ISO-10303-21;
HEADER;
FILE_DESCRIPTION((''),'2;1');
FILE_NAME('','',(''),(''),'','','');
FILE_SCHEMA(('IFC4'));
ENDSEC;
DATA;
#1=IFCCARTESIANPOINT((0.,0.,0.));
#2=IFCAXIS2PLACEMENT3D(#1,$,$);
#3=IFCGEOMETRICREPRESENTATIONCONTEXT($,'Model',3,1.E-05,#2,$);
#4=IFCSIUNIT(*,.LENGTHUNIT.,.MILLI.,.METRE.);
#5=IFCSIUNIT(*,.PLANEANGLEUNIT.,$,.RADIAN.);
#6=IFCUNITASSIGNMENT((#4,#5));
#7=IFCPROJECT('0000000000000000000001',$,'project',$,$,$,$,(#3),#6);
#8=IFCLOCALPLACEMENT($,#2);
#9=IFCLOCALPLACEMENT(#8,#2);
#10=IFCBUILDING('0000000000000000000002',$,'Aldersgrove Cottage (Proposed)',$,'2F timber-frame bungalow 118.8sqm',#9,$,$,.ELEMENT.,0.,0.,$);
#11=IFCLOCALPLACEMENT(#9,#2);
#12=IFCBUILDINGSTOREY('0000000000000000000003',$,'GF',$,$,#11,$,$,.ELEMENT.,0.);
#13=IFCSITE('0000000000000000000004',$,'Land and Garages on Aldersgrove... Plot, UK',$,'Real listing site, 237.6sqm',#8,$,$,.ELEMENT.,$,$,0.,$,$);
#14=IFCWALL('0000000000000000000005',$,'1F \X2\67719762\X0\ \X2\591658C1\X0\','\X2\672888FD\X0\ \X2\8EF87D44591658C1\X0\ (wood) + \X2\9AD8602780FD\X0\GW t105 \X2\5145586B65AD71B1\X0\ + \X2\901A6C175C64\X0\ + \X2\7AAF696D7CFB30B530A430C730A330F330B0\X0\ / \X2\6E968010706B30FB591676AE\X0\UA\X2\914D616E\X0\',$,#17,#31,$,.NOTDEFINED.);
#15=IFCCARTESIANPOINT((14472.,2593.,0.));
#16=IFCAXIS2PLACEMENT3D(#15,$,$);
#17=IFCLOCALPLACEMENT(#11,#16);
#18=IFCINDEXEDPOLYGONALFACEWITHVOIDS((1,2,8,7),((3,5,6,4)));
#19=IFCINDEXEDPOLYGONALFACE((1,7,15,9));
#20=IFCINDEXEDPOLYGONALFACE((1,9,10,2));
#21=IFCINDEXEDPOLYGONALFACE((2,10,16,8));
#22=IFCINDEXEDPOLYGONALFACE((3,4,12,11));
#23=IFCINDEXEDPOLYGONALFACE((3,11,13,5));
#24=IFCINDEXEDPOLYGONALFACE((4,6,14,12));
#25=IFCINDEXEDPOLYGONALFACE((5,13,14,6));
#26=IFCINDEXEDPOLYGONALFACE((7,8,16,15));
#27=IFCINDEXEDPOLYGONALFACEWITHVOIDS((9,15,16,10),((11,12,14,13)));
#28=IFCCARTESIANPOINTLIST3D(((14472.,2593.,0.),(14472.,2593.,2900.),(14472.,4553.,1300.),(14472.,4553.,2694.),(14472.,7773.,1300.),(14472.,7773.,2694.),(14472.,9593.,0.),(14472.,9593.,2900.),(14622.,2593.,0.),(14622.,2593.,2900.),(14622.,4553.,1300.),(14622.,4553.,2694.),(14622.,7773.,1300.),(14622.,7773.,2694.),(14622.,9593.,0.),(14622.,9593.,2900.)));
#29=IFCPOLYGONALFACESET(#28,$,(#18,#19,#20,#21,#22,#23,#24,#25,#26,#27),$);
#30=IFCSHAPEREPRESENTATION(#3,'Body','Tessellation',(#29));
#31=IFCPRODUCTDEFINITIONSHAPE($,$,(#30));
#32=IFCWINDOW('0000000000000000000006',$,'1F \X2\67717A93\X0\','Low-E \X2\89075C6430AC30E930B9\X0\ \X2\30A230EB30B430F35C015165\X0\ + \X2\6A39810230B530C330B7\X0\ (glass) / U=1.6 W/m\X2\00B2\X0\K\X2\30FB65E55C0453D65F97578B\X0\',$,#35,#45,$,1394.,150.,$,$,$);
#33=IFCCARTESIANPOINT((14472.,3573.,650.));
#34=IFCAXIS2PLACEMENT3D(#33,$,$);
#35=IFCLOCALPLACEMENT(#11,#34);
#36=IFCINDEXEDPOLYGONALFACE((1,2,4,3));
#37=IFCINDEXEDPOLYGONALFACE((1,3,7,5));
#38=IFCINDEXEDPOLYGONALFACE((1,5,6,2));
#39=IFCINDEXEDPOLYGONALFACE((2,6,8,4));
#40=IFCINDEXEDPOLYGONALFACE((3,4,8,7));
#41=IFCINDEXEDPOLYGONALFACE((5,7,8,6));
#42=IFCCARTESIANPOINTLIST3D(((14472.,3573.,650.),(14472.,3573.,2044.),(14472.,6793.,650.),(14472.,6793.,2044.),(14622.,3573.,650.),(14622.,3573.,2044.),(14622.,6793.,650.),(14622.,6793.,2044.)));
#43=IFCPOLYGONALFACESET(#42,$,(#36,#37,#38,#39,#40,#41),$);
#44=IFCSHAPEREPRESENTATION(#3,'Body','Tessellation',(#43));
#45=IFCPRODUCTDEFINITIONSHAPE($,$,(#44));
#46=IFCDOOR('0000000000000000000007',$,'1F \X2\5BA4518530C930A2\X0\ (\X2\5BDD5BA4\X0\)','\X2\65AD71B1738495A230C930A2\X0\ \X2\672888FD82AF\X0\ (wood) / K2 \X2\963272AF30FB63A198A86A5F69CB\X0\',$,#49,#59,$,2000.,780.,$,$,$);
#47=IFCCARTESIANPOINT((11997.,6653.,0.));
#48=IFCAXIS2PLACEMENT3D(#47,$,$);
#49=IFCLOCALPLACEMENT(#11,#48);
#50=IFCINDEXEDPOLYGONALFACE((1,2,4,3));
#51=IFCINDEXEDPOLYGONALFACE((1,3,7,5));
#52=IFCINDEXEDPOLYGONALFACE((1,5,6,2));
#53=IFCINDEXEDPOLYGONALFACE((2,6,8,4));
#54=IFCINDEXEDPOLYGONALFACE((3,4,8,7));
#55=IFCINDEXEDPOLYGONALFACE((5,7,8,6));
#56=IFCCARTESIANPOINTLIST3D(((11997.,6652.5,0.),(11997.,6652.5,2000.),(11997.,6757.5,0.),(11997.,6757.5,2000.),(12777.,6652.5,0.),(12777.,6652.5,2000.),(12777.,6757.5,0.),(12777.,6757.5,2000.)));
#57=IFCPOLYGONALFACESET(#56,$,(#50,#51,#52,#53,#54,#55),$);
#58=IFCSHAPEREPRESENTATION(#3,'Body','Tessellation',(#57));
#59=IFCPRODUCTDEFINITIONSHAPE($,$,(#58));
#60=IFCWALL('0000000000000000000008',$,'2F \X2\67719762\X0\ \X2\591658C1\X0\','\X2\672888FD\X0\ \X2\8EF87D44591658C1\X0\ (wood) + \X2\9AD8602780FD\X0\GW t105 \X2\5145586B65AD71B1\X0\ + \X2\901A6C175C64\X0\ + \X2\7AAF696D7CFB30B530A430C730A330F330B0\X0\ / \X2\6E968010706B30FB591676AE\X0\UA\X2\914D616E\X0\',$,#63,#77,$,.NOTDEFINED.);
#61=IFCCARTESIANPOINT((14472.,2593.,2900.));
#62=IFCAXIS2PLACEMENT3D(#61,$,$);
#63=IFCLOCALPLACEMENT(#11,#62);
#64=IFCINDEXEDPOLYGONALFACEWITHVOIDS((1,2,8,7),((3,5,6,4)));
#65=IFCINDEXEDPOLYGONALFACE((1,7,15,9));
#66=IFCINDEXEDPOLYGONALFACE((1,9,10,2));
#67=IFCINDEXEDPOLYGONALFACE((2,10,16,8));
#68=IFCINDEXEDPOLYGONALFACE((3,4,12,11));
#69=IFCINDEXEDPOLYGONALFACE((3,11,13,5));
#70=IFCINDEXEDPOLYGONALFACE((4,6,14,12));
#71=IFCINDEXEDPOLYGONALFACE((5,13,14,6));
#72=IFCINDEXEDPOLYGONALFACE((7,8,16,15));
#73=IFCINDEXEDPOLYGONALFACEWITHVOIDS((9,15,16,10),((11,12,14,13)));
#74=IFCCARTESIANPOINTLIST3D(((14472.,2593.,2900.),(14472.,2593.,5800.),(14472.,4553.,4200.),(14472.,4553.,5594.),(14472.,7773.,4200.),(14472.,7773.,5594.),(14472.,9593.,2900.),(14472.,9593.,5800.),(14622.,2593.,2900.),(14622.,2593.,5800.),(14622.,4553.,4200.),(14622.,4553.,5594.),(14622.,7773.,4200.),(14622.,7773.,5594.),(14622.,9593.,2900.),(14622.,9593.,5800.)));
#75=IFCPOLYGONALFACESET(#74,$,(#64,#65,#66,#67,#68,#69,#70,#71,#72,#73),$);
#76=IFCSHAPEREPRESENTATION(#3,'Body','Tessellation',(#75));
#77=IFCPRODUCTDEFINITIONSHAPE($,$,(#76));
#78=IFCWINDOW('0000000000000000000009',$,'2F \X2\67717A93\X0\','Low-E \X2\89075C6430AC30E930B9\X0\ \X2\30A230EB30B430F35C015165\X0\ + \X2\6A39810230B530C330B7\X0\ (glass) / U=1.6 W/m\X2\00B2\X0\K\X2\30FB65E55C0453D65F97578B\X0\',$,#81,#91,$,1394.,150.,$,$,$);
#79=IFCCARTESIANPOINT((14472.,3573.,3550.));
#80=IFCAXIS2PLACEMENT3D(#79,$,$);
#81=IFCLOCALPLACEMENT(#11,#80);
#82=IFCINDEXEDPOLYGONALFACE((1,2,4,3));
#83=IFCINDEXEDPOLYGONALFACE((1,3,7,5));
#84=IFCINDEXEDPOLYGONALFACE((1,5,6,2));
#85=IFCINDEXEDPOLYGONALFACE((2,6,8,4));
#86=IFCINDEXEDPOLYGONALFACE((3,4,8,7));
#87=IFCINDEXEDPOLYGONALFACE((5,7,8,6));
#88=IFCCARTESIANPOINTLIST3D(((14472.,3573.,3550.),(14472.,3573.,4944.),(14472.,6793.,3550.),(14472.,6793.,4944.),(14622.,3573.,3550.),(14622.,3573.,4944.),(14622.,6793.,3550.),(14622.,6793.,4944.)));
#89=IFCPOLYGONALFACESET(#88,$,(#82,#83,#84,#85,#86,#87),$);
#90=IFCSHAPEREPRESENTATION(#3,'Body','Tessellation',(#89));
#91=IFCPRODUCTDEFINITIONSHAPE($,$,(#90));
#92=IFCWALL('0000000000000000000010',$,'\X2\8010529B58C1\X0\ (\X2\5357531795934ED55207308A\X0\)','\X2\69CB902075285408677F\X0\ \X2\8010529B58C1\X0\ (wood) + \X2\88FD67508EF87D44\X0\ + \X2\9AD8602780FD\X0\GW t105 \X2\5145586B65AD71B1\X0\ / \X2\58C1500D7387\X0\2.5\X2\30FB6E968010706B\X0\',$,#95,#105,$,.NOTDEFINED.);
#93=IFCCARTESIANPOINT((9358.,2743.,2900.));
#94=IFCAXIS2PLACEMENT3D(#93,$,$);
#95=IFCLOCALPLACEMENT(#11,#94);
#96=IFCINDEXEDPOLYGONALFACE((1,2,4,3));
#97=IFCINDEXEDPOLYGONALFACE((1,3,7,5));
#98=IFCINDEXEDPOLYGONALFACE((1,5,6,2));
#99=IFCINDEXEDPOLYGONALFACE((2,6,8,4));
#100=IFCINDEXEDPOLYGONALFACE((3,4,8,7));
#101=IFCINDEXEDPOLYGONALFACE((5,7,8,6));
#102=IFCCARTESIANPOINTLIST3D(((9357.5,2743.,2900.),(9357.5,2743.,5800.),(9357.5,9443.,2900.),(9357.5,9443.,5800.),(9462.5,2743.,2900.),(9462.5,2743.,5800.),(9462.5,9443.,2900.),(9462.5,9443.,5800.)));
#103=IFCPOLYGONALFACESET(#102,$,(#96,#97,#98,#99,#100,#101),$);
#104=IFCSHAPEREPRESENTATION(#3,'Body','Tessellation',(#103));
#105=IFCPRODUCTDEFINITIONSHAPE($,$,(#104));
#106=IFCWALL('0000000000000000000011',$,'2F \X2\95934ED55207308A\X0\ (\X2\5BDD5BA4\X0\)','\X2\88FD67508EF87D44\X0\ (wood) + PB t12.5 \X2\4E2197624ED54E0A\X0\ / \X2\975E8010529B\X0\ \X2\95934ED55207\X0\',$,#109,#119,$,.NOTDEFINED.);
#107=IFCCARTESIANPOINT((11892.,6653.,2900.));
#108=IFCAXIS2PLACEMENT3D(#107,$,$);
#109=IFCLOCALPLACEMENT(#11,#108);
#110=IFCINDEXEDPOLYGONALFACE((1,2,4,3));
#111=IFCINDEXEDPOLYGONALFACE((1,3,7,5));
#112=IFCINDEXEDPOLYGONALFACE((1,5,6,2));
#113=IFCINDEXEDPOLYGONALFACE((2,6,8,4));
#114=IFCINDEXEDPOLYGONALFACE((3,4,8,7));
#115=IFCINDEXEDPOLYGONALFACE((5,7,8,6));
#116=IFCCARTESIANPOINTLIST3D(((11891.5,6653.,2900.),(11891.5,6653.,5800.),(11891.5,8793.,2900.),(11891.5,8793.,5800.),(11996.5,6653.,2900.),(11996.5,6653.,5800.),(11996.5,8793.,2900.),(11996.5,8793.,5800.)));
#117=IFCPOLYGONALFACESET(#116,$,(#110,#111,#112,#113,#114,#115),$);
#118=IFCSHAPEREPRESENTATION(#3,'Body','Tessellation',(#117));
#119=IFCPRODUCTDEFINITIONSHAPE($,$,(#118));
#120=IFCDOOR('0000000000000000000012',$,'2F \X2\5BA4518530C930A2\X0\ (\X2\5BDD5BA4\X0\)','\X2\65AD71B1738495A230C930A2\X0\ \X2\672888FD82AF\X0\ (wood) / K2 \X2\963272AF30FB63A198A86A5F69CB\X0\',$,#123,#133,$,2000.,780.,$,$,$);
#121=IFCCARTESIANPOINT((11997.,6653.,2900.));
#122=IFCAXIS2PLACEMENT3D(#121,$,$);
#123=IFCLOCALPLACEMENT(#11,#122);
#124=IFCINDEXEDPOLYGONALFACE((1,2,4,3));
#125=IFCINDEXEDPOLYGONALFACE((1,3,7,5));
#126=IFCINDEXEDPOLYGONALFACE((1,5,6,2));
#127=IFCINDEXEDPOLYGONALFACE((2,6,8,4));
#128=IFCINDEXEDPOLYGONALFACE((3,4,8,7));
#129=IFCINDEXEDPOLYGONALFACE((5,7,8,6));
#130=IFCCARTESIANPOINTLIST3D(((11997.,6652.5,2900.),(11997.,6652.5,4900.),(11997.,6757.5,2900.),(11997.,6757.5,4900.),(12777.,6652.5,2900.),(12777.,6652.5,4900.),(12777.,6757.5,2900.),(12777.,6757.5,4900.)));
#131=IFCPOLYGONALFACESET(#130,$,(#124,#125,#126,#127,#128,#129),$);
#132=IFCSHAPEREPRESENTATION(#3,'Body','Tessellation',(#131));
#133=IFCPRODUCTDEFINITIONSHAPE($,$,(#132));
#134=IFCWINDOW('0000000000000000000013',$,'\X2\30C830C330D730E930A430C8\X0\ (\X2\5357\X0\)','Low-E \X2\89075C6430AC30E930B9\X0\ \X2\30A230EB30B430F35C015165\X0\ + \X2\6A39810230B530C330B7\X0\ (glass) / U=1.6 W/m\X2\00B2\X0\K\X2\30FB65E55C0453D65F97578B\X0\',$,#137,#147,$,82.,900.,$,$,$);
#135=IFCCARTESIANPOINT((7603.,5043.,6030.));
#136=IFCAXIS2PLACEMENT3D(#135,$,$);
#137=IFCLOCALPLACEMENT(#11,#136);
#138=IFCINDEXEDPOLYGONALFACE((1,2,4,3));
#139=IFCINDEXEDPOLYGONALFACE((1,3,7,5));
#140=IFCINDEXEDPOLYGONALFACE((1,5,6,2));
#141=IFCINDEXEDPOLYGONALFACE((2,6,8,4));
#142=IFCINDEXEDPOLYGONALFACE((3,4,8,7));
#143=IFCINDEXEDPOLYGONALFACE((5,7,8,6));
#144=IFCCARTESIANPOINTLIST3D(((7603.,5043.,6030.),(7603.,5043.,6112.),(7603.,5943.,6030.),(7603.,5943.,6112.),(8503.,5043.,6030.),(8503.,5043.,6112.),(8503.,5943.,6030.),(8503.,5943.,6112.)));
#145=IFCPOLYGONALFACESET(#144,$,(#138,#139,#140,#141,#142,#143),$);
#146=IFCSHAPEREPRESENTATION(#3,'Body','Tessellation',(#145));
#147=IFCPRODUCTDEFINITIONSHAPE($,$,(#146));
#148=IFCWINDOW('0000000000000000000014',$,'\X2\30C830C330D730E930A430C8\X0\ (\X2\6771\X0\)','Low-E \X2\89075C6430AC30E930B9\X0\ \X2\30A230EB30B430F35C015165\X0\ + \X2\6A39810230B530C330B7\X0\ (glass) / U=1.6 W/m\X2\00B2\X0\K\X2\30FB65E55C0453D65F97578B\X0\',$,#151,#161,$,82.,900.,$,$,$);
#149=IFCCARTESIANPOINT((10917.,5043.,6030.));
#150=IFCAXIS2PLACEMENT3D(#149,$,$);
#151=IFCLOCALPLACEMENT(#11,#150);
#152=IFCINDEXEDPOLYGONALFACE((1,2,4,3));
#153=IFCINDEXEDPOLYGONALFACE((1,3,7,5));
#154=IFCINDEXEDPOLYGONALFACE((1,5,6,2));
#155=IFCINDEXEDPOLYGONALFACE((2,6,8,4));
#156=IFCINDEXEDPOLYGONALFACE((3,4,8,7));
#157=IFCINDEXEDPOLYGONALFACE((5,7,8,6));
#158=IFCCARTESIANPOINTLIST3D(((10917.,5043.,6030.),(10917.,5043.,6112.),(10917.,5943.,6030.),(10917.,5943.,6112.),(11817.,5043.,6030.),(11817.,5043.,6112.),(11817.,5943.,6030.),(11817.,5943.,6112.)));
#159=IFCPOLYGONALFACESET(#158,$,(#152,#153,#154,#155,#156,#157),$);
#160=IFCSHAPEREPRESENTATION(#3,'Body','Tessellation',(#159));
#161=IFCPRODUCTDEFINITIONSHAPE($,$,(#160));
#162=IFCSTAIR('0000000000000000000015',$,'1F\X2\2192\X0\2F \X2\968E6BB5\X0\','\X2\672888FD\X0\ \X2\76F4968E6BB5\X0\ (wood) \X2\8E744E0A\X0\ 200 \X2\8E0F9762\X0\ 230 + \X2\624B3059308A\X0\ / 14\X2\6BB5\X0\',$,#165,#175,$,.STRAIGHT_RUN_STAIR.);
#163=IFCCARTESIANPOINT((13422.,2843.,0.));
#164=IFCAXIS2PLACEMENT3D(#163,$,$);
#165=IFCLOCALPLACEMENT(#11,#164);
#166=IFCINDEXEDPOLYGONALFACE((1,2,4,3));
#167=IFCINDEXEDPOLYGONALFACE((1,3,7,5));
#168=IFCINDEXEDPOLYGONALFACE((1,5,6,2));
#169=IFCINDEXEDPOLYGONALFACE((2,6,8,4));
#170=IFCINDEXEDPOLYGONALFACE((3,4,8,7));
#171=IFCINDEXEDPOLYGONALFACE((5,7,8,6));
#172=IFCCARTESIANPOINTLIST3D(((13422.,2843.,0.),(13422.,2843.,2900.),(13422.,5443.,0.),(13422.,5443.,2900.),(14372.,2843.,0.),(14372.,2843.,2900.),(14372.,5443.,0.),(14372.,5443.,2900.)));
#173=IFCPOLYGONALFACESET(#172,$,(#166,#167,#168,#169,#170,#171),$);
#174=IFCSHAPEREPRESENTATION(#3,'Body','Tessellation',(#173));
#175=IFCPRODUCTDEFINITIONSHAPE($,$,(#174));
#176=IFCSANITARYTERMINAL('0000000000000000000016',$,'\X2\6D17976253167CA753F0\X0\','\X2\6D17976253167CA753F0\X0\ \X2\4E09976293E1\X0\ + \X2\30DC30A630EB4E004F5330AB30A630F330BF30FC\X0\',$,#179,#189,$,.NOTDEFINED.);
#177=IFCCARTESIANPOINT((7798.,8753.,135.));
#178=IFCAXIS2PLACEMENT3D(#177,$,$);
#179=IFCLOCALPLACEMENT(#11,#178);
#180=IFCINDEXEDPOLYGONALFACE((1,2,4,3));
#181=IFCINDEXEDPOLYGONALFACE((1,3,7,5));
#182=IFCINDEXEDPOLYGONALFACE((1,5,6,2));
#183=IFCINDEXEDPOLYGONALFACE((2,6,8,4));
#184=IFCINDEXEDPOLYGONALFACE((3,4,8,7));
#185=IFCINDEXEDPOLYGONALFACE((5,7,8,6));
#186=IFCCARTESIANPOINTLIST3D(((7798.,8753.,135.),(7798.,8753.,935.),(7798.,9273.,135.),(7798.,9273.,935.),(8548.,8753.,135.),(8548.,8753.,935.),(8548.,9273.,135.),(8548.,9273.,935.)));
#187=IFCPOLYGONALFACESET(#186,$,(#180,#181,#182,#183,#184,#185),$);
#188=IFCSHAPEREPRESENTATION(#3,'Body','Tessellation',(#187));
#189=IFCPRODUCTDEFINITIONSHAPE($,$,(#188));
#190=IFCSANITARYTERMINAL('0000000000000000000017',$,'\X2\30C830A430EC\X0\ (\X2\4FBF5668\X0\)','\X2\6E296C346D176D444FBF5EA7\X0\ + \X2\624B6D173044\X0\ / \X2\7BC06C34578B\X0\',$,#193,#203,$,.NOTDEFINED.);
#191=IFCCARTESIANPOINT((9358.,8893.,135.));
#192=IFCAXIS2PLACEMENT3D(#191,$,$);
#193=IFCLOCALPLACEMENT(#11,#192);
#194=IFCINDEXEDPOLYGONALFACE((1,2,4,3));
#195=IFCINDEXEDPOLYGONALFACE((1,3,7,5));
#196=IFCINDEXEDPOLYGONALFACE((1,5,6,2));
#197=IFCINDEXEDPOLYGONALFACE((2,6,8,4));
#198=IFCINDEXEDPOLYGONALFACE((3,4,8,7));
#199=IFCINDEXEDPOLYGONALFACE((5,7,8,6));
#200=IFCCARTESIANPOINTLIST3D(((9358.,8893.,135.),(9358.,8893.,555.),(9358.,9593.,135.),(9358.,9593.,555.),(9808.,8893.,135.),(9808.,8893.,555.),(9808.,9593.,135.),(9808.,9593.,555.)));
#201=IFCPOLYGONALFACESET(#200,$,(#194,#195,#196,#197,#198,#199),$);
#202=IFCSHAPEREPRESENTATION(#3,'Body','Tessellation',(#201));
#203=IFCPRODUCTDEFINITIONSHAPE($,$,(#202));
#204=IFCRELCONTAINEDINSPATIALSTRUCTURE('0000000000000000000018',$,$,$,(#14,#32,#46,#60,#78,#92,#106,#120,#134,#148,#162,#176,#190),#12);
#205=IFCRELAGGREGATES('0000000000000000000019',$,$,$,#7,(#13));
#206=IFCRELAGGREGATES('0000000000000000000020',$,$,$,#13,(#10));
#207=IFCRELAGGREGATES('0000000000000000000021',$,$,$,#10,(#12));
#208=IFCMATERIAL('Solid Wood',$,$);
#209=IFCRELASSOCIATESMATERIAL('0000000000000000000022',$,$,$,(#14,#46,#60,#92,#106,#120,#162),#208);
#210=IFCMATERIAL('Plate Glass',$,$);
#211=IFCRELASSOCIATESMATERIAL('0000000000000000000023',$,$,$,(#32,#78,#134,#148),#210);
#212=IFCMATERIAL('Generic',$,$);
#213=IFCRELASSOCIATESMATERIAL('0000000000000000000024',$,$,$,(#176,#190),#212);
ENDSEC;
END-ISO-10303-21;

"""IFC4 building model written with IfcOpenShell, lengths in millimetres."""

from ifc_helpers import new_model, si_unit, frame, frame_2d, origin, place, context, project, spatial, rectangle, extrude, material, element, fill, save


model = new_model("IFC4")

# Units and contexts
model_context = context("Model", 3, precision=1e-05, world=origin())
ifc_project = project(units=[si_unit("LENGTHUNIT", "METRE", prefix="MILLI"), si_unit("PLANEANGLEUNIT", "RADIAN")], contexts=[model_context])

# Site, building, storey
site_placement = place(None, origin())
site = spatial("IfcSite", under=ifc_project, at=site_placement, Name="Land and Garages on Aldersgrove... Plot, UK", ObjectType="Real listing site, 237.6sqm", CompositionType="ELEMENT", RefElevation=0.0)
building_placement = place(site_placement, origin())
building = spatial("IfcBuilding", under=site, at=building_placement, Name="Aldersgrove Cottage (Proposed)", ObjectType="2F timber-frame bungalow 118.8sqm", CompositionType="ELEMENT", ElevationOfRefHeight=0.0, ElevationOfTerrain=0.0)
storey_placement = place(building_placement, origin())
storey = spatial("IfcBuildingStorey", under=building, at=storey_placement, Name="GF", CompositionType="ELEMENT", Elevation=0.0)

# Wall, opening, window
ifc_material_1 = material(Name="Solid Wood")
wall_1_placement = place(storey_placement, frame((14472.0, 2593.0, 0.0)))
wall_1 = element("IfcWall", 1, at=wall_1_placement, inside=storey, material=ifc_material_1, Name="1F 東面 外壁", Description="木製 軸組外壁 (wood) + 高性能GW t105 充填断熱 + 通気層 + 窯業系サイディング / 準耐火・外皮UA配慮", PredefinedType="NOTDEFINED", context=model_context, shape_type="SweptSolid", body=[
    extrude(rectangle(XDim=150.0, YDim=7000.0, at=frame_2d((75.0, 3500.0))), frame((14472.0, 2593.0, 0.0)), (0.0, 0.0, 1.0), 2900.0),
])
opening_1_placement = place(storey_placement, frame((14472.0, 3573.0, 650.0)))
opening_1 = element("IfcOpeningElement", 2, at=opening_1_placement, cuts=wall_1, PredefinedType="NOTDEFINED", context=model_context, shape_type="SweptSolid", body=[
    extrude(rectangle(XDim=150.0, YDim=3220.0, at=frame_2d((75.0, 1610.0))), frame((14472.0, 3573.0, 650.0)), (0.0, 0.0, 1.0), 1394.0),
])
ifc_material_2 = material(Name="Plate Glass")
window_1_placement = place(storey_placement, frame((14472.0, 3573.0, 650.0)))
window_1 = element("IfcWindow", 3, at=window_1_placement, inside=storey, material=ifc_material_2, Name="1F 東窓", Description="Low-E 複層ガラス アルゴン封入 + 樹脂サッシ (glass) / U=1.6 W/m²K・日射取得型", OverallHeight=1394.0, OverallWidth=150.0, context=model_context, shape_type="SweptSolid", body=[
    extrude(rectangle(XDim=150.0, YDim=3220.0, at=frame_2d((75.0, 1610.0))), frame((14472.0, 3573.0, 650.0)), (0.0, 0.0, 1.0), 1394.0),
])
fill(opening_1, window_1)

# Door
door_1_placement = place(storey_placement, frame((11997.0, 6653.0, 0.0)))
element("IfcDoor", 4, at=door_1_placement, inside=storey, material=ifc_material_1, Name="1F 室内ドア (寝室)", Description="断熱玄関ドア 木製芯 (wood) / K2 防犯・採風機構", OverallHeight=2000.0, OverallWidth=780.0, context=model_context, shape_type="SweptSolid", body=[
    extrude(rectangle(XDim=780.0, YDim=105.0, at=frame_2d((390.0, 52.0))), frame((11997.0, 6653.0, 0.0)), (0.0, 0.0, 1.0), 2000.0),
])

# Wall, opening, window
wall_2_placement = place(storey_placement, frame((14472.0, 2593.0, 2900.0)))
wall_2 = element("IfcWall", 5, at=wall_2_placement, inside=storey, material=ifc_material_1, Name="2F 東面 外壁", Description="木製 軸組外壁 (wood) + 高性能GW t105 充填断熱 + 通気層 + 窯業系サイディング / 準耐火・外皮UA配慮", PredefinedType="NOTDEFINED", context=model_context, shape_type="SweptSolid", body=[
    extrude(rectangle(XDim=150.0, YDim=7000.0, at=frame_2d((75.0, 3500.0))), frame((14472.0, 2593.0, 2900.0)), (0.0, 0.0, 1.0), 2900.0),
])
opening_2_placement = place(storey_placement, frame((14472.0, 3573.0, 3550.0)))
opening_2 = element("IfcOpeningElement", 6, at=opening_2_placement, cuts=wall_2, PredefinedType="NOTDEFINED", context=model_context, shape_type="SweptSolid", body=[
    extrude(rectangle(XDim=150.0, YDim=3220.0, at=frame_2d((75.0, 1610.0))), frame((14472.0, 3573.0, 3550.0)), (0.0, 0.0, 1.0), 1394.0),
])
window_2_placement = place(storey_placement, frame((14472.0, 3573.0, 3550.0)))
window_2 = element("IfcWindow", 7, at=window_2_placement, inside=storey, material=ifc_material_2, Name="2F 東窓", Description="Low-E 複層ガラス アルゴン封入 + 樹脂サッシ (glass) / U=1.6 W/m²K・日射取得型", OverallHeight=1394.0, OverallWidth=150.0, context=model_context, shape_type="SweptSolid", body=[
    extrude(rectangle(XDim=150.0, YDim=3220.0, at=frame_2d((75.0, 1610.0))), frame((14472.0, 3573.0, 3550.0)), (0.0, 0.0, 1.0), 1394.0),
])
fill(opening_2, window_2)

# Walls
wall_3_placement = place(storey_placement, frame((9358.0, 2743.0, 2900.0)))
element("IfcWall", 8, at=wall_3_placement, inside=storey, material=ifc_material_1, Name="耐力壁 (南北間仕切り)", Description="構造用合板 耐力壁 (wood) + 製材軸組 + 高性能GW t105 充填断熱 / 壁倍率2.5・準耐火", PredefinedType="NOTDEFINED", context=model_context, shape_type="SweptSolid", body=[
    extrude(rectangle(XDim=105.0, YDim=6700.0, at=frame_2d((52.0, 3350.0))), frame((9358.0, 2743.0, 2900.0)), (0.0, 0.0, 1.0), 2900.0),
])
wall_4_placement = place(storey_placement, frame((11892.0, 6653.0, 2900.0)))
element("IfcWall", 9, at=wall_4_placement, inside=storey, material=ifc_material_1, Name="2F 間仕切り (寝室)", Description="製材軸組 (wood) + PB t12.5 両面仕上 / 非耐力 間仕切", PredefinedType="NOTDEFINED", context=model_context, shape_type="SweptSolid", body=[
    extrude(rectangle(XDim=105.0, YDim=2140.0, at=frame_2d((52.0, 1070.0))), frame((11892.0, 6653.0, 2900.0)), (0.0, 0.0, 1.0), 2900.0),
])

# Door
door_2_placement = place(storey_placement, frame((11997.0, 6653.0, 2900.0)))
element("IfcDoor", 10, at=door_2_placement, inside=storey, material=ifc_material_1, Name="2F 室内ドア (寝室)", Description="断熱玄関ドア 木製芯 (wood) / K2 防犯・採風機構", OverallHeight=2000.0, OverallWidth=780.0, context=model_context, shape_type="SweptSolid", body=[
    extrude(rectangle(XDim=780.0, YDim=105.0, at=frame_2d((390.0, 52.0))), frame((11997.0, 6653.0, 2900.0)), (0.0, 0.0, 1.0), 2000.0),
])

# Windows
window_3_placement = place(storey_placement, frame((7603.0, 5043.0, 6030.0)))
element("IfcWindow", 11, at=window_3_placement, inside=storey, material=ifc_material_2, Name="トップライト (南)", Description="Low-E 複層ガラス アルゴン封入 + 樹脂サッシ (glass) / U=1.6 W/m²K・日射取得型", OverallHeight=82.0, OverallWidth=900.0, context=model_context, shape_type="SweptSolid", body=[
    extrude(rectangle(XDim=900.0, YDim=900.0, at=frame_2d((450.0, 450.0))), frame((7603.0, 5043.0, 6030.0)), (0.0, 0.0, 1.0), 82.0),
])
window_4_placement = place(storey_placement, frame((10917.0, 5043.0, 6030.0)))
element("IfcWindow", 12, at=window_4_placement, inside=storey, material=ifc_material_2, Name="トップライト (東)", Description="Low-E 複層ガラス アルゴン封入 + 樹脂サッシ (glass) / U=1.6 W/m²K・日射取得型", OverallHeight=82.0, OverallWidth=900.0, context=model_context, shape_type="SweptSolid", body=[
    extrude(rectangle(XDim=900.0, YDim=900.0, at=frame_2d((450.0, 450.0))), frame((10917.0, 5043.0, 6030.0)), (0.0, 0.0, 1.0), 82.0),
])

# Stair
stair_placement = place(storey_placement, frame((13422.0, 2843.0, 0.0)))
element("IfcStair", 13, at=stair_placement, inside=storey, material=ifc_material_1, Name="1F→2F 階段", Description="木製 直階段 (wood) 蹴上 200 踏面 230 + 手すり / 14段", PredefinedType="STRAIGHT_RUN_STAIR", context=model_context, shape_type="SweptSolid", body=[
    extrude(rectangle(XDim=950.0, YDim=2600.0, at=frame_2d((475.0, 1300.0))), frame((13422.0, 2843.0, 0.0)), (0.0, 0.0, 1.0), 2900.0),
])

# Sanitary terminals
ifc_material_3 = material(Name="Generic")
sanitary_terminal_1_placement = place(storey_placement, frame((7798.0, 8753.0, 135.0)))
element("IfcSanitaryTerminal", 14, at=sanitary_terminal_1_placement, inside=storey, material=ifc_material_3, Name="洗面化粧台", Description="洗面化粧台 三面鏡 + ボウル一体カウンター", PredefinedType="NOTDEFINED", context=model_context, shape_type="SweptSolid", body=[
    extrude(rectangle(XDim=750.0, YDim=520.0, at=frame_2d((375.0, 260.0))), frame((7798.0, 8753.0, 135.0)), (0.0, 0.0, 1.0), 800.0),
])
sanitary_terminal_2_placement = place(storey_placement, frame((9358.0, 8893.0, 135.0)))
element("IfcSanitaryTerminal", 15, at=sanitary_terminal_2_placement, inside=storey, material=ifc_material_3, Name="トイレ (便器)", Description="温水洗浄便座 + 手洗い / 節水型", PredefinedType="NOTDEFINED", context=model_context, shape_type="SweptSolid", body=[
    extrude(rectangle(XDim=450.0, YDim=700.0, at=frame_2d((225.0, 350.0))), frame((9358.0, 8893.0, 135.0)), (0.0, 0.0, 1.0), 420.0),
])

save(model, "model.ifc")
